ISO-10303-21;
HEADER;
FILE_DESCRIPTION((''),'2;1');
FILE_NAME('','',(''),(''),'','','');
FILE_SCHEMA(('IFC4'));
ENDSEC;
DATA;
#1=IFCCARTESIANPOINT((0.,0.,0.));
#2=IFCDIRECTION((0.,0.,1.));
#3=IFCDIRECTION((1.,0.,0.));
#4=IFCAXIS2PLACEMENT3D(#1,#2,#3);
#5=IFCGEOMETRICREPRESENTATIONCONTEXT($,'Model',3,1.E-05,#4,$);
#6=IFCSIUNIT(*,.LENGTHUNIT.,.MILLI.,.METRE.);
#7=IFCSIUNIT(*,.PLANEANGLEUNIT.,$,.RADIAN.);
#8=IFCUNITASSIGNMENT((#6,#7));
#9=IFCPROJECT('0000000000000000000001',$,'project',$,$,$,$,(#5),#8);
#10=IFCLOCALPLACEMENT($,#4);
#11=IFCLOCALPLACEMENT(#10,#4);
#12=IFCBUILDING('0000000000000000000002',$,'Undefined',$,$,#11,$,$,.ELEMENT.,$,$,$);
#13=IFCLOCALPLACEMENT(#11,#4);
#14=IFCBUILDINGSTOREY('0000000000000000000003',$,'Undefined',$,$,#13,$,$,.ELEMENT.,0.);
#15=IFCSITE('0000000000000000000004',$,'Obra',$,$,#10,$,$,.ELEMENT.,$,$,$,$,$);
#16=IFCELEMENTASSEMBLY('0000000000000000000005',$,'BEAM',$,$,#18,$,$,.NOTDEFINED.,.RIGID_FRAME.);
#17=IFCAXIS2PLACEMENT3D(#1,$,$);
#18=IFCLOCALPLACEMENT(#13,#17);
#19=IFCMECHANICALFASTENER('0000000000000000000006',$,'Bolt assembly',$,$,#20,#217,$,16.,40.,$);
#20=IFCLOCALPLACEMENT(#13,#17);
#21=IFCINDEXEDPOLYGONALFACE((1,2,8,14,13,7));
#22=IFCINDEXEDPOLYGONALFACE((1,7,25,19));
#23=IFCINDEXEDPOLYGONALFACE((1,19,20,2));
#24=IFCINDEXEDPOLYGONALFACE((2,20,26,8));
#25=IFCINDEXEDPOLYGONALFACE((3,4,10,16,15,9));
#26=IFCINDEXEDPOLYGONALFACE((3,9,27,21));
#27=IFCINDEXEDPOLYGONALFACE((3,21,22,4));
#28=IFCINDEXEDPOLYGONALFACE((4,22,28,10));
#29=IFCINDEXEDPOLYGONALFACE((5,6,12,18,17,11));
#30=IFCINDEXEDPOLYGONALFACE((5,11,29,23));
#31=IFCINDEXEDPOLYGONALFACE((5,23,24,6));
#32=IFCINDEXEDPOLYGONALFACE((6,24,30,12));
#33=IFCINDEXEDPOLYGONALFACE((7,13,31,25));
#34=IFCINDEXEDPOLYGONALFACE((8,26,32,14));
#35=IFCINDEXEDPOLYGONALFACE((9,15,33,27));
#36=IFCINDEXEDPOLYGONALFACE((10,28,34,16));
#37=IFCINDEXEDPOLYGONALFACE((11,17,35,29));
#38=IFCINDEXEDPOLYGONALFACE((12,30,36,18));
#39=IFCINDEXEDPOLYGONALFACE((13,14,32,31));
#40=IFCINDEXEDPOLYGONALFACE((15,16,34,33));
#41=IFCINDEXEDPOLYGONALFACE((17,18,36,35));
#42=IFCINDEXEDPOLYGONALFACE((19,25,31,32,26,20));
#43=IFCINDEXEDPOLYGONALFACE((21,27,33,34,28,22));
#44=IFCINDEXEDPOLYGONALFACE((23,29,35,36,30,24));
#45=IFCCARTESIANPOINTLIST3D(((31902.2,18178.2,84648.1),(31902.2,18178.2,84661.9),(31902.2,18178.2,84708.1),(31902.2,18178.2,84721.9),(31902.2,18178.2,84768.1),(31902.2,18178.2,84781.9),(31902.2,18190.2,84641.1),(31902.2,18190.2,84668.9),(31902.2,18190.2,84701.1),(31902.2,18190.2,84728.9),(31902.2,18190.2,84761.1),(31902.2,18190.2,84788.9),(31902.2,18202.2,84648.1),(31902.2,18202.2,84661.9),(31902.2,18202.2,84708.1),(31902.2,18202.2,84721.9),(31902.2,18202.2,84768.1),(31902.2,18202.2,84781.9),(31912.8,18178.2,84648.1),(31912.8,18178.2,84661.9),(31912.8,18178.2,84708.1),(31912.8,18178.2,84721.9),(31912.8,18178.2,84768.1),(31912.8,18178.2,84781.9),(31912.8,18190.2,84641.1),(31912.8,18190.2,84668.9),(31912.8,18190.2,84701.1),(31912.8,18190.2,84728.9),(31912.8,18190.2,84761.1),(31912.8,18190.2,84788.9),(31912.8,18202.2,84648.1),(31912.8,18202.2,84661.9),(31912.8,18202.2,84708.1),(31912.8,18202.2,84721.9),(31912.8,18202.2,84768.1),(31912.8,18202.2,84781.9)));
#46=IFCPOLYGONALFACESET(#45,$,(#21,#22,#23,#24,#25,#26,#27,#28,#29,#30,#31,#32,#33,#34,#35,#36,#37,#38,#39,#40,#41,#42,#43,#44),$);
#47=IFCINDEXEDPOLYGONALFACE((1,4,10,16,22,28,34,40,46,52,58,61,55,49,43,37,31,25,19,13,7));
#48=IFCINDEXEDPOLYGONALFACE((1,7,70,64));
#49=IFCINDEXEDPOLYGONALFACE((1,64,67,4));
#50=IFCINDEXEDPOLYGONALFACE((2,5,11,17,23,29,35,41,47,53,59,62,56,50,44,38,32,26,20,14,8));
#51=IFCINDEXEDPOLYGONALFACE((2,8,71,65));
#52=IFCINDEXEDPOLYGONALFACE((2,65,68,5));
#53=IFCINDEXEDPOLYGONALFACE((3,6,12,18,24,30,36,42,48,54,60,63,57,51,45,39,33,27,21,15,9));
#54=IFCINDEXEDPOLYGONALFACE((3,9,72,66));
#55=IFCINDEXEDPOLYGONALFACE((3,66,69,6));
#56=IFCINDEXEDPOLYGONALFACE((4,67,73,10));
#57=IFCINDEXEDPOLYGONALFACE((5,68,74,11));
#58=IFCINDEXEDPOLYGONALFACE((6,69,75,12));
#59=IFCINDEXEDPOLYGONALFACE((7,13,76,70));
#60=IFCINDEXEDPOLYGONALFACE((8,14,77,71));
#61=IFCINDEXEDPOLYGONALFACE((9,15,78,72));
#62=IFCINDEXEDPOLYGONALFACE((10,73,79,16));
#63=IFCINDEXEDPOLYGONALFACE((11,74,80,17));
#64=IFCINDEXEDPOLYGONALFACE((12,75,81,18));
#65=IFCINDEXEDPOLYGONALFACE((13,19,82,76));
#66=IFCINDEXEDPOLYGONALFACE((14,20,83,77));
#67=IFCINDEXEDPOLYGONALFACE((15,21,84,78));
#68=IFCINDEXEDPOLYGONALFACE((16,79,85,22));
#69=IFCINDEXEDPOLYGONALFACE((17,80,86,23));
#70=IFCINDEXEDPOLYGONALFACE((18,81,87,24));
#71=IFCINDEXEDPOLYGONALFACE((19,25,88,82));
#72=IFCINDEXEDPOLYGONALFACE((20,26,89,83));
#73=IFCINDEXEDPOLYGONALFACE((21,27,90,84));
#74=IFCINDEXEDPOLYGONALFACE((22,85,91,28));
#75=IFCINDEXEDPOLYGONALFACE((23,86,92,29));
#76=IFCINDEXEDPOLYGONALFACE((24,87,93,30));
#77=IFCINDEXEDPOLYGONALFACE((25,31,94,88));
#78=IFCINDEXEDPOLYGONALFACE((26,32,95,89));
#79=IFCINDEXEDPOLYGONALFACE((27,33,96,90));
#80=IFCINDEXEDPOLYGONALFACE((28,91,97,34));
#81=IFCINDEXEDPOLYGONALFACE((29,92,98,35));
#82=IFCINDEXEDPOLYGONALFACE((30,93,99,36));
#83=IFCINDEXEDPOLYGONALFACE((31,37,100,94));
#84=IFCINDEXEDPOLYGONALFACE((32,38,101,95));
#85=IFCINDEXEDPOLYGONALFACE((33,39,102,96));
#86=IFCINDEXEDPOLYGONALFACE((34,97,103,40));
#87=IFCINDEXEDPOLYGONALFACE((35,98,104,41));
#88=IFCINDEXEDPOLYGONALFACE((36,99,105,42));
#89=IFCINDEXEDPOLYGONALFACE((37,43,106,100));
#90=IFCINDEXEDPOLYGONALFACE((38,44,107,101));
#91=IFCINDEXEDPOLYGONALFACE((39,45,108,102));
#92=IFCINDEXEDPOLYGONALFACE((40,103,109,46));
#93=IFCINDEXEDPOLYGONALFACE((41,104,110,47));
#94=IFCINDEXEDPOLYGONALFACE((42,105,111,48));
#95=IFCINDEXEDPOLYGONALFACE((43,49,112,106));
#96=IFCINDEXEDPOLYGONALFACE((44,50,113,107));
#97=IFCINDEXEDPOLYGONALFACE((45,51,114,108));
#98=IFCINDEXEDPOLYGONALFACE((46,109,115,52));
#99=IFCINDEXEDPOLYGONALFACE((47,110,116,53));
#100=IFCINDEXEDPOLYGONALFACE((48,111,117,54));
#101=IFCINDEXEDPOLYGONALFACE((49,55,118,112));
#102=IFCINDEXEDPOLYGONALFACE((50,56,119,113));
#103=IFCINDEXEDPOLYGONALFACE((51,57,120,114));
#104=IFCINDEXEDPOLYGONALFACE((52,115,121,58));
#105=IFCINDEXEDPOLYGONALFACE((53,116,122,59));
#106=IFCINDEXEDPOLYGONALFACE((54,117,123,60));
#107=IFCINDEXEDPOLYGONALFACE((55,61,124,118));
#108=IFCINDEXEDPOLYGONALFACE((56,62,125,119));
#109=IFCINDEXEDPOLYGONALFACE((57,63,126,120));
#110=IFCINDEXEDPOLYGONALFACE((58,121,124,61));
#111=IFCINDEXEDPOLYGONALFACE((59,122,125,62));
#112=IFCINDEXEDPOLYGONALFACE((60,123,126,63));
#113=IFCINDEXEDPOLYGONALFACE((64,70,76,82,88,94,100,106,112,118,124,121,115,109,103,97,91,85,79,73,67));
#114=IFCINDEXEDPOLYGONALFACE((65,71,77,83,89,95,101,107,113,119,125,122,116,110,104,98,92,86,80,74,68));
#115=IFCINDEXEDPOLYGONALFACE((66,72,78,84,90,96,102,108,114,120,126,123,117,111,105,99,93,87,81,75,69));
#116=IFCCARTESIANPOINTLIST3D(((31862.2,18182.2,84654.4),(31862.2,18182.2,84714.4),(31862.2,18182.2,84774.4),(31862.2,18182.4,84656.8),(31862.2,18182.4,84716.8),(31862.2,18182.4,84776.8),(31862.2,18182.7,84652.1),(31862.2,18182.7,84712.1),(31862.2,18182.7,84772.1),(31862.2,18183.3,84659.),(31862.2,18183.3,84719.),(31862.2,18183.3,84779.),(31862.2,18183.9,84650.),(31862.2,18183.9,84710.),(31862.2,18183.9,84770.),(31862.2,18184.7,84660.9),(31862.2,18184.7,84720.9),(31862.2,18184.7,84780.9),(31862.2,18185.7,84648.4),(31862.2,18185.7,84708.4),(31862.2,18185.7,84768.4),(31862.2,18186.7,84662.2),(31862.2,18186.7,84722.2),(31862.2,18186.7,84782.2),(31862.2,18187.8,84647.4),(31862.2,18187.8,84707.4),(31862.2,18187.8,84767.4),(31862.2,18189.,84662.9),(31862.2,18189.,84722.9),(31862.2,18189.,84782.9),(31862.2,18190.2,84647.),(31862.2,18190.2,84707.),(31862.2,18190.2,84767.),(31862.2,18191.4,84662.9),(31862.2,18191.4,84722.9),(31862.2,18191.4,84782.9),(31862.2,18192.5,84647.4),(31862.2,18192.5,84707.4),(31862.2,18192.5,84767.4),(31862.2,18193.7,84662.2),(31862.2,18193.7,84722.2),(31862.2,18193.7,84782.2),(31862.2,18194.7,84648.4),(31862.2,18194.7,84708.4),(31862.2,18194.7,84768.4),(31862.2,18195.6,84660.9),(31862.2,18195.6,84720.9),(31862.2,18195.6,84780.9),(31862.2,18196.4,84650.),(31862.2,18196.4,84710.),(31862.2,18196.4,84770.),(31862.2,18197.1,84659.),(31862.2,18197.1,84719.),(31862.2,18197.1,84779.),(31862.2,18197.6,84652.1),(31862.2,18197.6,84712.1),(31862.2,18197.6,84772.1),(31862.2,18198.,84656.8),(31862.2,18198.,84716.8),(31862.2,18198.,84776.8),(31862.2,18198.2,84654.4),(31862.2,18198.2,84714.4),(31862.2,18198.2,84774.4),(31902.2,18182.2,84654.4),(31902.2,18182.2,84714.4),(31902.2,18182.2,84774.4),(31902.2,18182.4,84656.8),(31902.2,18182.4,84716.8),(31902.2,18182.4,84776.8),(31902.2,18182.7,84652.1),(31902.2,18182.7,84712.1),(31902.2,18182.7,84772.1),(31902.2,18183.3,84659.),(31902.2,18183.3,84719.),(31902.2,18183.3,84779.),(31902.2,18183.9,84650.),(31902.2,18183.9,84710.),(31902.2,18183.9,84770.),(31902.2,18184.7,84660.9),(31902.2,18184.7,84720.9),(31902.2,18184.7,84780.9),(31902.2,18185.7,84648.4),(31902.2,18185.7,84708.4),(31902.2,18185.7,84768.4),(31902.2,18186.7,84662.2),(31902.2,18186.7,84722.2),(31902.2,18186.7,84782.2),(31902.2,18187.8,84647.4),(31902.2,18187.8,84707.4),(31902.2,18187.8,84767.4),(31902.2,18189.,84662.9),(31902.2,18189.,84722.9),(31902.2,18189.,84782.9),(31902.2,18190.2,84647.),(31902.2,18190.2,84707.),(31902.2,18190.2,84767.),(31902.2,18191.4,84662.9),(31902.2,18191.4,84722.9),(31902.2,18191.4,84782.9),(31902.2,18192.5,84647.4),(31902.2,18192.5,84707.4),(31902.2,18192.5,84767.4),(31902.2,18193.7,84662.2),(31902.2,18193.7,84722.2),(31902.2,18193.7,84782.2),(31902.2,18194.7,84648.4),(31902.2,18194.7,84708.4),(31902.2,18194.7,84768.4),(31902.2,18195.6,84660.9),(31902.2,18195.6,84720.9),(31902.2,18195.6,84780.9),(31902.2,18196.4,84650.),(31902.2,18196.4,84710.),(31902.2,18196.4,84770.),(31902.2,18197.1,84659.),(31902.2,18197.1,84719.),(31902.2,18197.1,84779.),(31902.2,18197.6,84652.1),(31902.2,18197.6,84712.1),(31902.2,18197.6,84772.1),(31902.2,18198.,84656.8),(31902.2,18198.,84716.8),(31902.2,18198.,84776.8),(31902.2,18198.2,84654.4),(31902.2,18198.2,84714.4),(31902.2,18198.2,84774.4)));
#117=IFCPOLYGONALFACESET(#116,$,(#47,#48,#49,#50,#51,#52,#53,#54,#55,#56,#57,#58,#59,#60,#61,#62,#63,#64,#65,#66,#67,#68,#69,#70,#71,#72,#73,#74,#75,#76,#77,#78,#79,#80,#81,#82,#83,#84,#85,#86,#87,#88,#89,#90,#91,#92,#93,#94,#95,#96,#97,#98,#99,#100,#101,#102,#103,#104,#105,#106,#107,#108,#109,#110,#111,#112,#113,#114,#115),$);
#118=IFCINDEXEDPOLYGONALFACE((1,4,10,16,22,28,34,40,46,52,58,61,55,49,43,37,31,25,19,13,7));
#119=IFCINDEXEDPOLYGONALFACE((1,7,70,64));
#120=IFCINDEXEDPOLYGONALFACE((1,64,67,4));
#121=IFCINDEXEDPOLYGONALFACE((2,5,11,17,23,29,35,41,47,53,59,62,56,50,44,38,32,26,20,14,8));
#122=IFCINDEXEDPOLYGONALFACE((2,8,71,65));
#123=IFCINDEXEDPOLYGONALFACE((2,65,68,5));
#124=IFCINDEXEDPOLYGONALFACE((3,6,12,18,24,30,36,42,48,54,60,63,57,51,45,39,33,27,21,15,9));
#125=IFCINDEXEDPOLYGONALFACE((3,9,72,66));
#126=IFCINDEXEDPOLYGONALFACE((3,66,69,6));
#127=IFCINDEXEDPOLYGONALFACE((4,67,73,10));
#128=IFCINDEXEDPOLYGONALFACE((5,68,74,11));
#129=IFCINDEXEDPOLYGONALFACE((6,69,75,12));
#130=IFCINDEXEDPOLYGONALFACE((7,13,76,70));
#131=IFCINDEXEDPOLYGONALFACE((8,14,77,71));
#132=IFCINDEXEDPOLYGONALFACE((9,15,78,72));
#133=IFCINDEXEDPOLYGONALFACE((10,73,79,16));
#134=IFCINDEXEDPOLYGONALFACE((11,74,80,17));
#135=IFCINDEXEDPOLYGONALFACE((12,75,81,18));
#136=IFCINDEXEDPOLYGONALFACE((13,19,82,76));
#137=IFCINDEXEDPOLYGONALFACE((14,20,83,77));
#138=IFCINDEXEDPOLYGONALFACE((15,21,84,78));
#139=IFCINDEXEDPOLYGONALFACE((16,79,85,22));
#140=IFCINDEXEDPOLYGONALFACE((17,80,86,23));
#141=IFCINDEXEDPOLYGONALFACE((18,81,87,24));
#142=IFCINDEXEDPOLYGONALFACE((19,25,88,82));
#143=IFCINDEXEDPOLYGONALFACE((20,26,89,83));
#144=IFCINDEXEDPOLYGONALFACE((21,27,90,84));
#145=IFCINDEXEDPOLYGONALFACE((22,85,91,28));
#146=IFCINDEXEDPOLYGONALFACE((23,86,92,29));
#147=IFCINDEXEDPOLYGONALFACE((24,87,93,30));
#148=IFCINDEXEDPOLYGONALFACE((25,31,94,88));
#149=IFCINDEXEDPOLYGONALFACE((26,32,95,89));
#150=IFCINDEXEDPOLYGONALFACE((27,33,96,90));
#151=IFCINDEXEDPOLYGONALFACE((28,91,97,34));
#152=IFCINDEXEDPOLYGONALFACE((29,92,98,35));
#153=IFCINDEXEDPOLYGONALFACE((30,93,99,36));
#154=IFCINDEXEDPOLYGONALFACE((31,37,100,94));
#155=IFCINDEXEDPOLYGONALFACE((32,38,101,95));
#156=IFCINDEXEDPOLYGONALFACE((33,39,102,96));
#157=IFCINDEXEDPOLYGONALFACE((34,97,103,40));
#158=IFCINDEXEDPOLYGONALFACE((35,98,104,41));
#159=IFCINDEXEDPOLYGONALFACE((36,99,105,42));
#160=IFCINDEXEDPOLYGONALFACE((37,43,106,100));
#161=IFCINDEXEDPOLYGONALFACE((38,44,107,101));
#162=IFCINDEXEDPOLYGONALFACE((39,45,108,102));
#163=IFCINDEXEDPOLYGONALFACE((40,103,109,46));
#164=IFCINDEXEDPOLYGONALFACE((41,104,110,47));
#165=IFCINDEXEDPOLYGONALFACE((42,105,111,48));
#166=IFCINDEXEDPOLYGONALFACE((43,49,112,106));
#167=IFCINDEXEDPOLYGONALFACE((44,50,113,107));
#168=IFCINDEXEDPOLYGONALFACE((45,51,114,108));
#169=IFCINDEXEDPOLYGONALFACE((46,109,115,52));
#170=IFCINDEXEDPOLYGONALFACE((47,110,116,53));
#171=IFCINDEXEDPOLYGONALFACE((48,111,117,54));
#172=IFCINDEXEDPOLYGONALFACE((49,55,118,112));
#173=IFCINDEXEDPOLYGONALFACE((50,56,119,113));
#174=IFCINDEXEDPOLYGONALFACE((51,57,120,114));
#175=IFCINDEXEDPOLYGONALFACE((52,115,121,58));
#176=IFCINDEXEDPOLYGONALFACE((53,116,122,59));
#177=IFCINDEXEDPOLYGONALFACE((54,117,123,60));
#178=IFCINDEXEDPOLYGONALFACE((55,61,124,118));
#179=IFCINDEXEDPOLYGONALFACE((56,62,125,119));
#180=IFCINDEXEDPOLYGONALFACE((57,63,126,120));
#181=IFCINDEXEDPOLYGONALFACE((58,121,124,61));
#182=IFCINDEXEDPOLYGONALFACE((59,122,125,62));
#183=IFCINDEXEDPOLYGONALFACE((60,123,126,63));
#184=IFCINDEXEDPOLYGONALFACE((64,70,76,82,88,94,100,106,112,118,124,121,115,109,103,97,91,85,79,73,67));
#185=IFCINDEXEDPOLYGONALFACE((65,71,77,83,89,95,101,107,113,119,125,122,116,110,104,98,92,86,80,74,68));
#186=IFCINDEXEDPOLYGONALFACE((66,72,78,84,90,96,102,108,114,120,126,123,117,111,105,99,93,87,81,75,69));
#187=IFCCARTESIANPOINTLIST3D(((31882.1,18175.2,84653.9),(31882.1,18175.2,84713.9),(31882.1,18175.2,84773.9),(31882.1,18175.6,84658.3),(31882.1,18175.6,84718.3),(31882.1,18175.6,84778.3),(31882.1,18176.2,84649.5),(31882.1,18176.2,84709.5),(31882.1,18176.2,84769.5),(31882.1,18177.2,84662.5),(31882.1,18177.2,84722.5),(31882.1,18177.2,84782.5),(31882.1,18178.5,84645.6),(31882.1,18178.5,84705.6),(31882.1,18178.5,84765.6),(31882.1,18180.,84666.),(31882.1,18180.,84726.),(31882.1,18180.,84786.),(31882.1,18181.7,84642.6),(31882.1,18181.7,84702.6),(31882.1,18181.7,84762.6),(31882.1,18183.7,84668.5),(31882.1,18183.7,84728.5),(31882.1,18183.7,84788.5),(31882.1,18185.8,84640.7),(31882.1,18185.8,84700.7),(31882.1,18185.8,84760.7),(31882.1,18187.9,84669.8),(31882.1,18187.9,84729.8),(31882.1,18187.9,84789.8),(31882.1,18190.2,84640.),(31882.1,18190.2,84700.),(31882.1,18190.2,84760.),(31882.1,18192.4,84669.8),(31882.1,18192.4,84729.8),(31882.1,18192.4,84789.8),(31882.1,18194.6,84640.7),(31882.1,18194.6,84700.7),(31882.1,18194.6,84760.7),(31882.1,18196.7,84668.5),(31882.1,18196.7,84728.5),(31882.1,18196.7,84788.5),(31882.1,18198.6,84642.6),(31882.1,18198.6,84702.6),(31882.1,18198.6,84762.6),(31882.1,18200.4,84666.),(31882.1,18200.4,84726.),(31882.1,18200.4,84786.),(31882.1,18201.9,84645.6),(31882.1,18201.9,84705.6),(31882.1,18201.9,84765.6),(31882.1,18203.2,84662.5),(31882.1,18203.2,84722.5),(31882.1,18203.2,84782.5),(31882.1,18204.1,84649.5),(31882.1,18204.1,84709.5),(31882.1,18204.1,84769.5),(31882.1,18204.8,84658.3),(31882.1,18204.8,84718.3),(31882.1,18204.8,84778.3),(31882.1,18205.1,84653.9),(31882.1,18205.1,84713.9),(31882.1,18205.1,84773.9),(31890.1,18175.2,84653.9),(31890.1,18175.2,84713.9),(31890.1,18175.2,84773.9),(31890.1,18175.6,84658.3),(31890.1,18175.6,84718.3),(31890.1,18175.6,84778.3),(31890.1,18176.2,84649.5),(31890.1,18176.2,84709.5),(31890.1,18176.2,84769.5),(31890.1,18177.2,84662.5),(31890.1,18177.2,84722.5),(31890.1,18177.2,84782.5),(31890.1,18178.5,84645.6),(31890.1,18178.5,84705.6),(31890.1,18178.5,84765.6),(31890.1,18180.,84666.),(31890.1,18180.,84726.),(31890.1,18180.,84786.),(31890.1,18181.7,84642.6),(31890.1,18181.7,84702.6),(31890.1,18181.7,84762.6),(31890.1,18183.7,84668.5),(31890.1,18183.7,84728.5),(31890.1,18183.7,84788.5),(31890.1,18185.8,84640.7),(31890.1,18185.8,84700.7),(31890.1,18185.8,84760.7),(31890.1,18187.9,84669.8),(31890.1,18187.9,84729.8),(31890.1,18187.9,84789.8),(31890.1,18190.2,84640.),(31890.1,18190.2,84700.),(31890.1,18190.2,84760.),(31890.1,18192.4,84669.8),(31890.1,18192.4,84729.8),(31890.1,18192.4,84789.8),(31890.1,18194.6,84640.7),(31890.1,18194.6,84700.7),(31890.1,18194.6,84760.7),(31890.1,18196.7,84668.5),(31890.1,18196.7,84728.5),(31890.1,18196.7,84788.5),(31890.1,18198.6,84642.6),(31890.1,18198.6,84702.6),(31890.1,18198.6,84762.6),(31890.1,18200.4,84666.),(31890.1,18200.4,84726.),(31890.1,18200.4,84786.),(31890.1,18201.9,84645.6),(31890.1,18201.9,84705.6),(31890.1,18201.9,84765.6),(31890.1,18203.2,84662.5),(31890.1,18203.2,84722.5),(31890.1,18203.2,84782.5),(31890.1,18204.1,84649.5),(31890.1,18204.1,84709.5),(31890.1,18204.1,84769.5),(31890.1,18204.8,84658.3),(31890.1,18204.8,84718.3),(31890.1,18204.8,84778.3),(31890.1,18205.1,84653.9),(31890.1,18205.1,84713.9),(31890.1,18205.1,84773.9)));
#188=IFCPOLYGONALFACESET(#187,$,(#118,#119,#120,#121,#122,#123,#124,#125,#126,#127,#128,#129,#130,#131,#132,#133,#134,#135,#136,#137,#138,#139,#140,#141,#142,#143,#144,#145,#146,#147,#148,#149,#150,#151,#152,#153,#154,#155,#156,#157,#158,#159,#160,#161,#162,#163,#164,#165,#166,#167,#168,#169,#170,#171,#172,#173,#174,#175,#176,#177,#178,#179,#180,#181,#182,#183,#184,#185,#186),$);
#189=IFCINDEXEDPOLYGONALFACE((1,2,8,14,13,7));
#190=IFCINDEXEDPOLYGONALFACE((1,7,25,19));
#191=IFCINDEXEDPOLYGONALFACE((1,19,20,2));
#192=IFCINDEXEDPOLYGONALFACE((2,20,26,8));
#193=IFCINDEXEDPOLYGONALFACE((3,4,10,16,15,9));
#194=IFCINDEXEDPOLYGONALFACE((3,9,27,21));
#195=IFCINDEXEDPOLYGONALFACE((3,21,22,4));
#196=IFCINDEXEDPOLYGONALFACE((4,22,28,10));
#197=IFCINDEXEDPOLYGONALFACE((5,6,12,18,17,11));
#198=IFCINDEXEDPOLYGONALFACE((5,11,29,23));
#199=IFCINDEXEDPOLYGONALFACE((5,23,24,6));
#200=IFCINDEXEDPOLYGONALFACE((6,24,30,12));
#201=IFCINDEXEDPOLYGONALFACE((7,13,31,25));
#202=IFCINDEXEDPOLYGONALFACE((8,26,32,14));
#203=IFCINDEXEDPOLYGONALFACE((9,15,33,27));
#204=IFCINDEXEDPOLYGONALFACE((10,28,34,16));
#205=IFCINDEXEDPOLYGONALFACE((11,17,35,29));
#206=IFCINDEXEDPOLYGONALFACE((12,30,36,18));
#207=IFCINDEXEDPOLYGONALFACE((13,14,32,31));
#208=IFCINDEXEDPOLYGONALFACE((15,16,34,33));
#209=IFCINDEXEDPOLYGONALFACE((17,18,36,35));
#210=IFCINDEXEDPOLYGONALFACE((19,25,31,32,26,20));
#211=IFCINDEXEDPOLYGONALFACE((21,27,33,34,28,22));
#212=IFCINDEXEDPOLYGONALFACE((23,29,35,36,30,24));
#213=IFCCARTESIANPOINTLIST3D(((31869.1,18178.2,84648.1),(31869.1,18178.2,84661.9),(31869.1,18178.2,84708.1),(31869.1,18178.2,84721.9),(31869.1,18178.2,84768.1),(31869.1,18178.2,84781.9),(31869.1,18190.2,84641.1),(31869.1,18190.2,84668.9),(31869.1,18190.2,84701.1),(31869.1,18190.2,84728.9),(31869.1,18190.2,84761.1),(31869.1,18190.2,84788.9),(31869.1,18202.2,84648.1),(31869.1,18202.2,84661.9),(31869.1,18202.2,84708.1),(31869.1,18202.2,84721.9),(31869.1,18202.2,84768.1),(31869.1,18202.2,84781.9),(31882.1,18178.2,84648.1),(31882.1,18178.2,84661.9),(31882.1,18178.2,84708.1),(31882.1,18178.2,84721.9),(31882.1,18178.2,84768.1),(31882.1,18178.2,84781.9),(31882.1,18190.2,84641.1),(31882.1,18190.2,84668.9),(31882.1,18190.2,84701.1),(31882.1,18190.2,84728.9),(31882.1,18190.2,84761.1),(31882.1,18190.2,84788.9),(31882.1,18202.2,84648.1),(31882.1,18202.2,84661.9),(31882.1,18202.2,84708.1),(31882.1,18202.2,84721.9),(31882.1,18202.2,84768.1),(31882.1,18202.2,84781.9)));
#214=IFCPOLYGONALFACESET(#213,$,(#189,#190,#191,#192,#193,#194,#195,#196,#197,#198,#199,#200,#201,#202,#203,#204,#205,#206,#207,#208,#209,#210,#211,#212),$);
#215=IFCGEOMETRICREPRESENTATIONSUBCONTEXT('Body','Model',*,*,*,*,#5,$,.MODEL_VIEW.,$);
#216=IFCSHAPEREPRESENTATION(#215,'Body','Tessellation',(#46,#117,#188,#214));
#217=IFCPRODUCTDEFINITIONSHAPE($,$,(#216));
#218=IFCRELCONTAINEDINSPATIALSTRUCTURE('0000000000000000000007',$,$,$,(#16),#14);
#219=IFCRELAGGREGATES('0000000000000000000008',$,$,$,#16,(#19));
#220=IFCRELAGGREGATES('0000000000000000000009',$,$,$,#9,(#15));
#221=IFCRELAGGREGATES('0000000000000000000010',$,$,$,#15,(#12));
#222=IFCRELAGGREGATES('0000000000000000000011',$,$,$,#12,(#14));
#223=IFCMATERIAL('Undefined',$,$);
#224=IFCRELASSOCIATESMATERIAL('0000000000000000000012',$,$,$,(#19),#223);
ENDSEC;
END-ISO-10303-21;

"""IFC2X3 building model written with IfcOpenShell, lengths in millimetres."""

from ifc_helpers import new_model, si_unit, frame, origin_with_axes, origin_2d_with_axis, place, context, subcontext, project, spatial, polyline, circle, outline, extrude, source, transform, mapped, material, element, aggregate, save


model = new_model("IFC2X3")

# Units and contexts
model_context = context("Model", 3, precision=1e-05, world=origin_with_axes())
body_context = subcontext(model_context, "Body", "Model", "MODEL_VIEW")
ifc_project = project(units=[si_unit("LENGTHUNIT", "METRE", prefix="MILLI"), si_unit("PLANEANGLEUNIT", "RADIAN")], contexts=[model_context])

# Site, building, storey
site_placement = place(None, origin_with_axes())
site = spatial("IfcSite", under=ifc_project, at=site_placement, Name="Obra", CompositionType="ELEMENT")
building_placement = place(site_placement, origin_with_axes())
building = spatial("IfcBuilding", under=site, at=building_placement, Name="Undefined", CompositionType="ELEMENT")
storey_placement = place(building_placement, origin_with_axes())
storey = spatial("IfcBuildingStorey", under=building, at=storey_placement, Name="Undefined", CompositionType="ELEMENT", Elevation=0.0)

# Shared definitions
ifc_material_1 = material(Name="Undefined")

# Element assembly, mechanical fastener
assembly_1_placement = place(storey_placement, origin_with_axes())
assembly_1 = element("IfcElementAssembly", 1, at=assembly_1_placement, inside=storey, Name="BEAM", AssemblyPlace="NOTDEFINED", PredefinedType="RIGID_FRAME")
shared_shape_1 = source(origin_with_axes(), body_context, "Body", "SweptSolid", [
    extrude(outline(polyline([(13.9, 0.0), (6.9, 12.0), (-6.9, 12.0), (-13.9, 0.0), (-6.9, -12.0), (6.9, -12.0), (13.9, 0.0)])), frame((0.0, -19.7, 0.0), z_axis=(0.0, 1.0, 0.0), x_axis=(1.0, 0.0, 0.0)), (0.0, 0.0, 1.0), 10.6),
    extrude(circle(Radius=8.0, at=origin_2d_with_axis()), frame((0.0, -9.1, 0.0), z_axis=(0.0, 1.0, 0.0), x_axis=(1.0, 0.0, 0.0)), (0.0, 0.0, 1.0), 40.0),
    extrude(circle(Radius=15.0, at=origin_2d_with_axis()), frame((0.0, 3.0, 0.0), z_axis=(0.0, 1.0, 0.0), x_axis=(1.0, 0.0, 0.0)), (0.0, 0.0, 1.0), 8.0),
    extrude(outline(polyline([(13.9, 0.0), (6.9, 12.0), (-6.9, 12.0), (-13.9, 0.0), (-6.9, -12.0), (6.9, -12.0), (13.9, 0.0)])), frame((0.0, 11.0, 0.0), z_axis=(0.0, 1.0, 0.0), x_axis=(1.0, 0.0, 0.0)), (0.0, 0.0, 1.0), 13.0),
])
mechanical_fastener_1_placement = place(assembly_1_placement, frame((31893.1, 18140.2, 84835.0), z_axis=(-0.000002, 1.0, 0.0), x_axis=(0.0, 0.0, -1.0)))
mechanical_fastener_1 = element("IfcMechanicalFastener", 2, at=mechanical_fastener_1_placement, material=ifc_material_1, Name="Bolt assembly", NominalDiameter=16.0, NominalLength=40.0, context=body_context, shape_type="MappedRepresentation", body=[
    mapped(shared_shape_1, transform((60.0, 0.0, 50.0))),
    mapped(shared_shape_1, transform((120.0, 0.0, 50.0))),
    mapped(shared_shape_1, transform((180.0, 0.0, 50.0))),
])

aggregate(assembly_1, [mechanical_fastener_1])

save(model, "model.ifc")
